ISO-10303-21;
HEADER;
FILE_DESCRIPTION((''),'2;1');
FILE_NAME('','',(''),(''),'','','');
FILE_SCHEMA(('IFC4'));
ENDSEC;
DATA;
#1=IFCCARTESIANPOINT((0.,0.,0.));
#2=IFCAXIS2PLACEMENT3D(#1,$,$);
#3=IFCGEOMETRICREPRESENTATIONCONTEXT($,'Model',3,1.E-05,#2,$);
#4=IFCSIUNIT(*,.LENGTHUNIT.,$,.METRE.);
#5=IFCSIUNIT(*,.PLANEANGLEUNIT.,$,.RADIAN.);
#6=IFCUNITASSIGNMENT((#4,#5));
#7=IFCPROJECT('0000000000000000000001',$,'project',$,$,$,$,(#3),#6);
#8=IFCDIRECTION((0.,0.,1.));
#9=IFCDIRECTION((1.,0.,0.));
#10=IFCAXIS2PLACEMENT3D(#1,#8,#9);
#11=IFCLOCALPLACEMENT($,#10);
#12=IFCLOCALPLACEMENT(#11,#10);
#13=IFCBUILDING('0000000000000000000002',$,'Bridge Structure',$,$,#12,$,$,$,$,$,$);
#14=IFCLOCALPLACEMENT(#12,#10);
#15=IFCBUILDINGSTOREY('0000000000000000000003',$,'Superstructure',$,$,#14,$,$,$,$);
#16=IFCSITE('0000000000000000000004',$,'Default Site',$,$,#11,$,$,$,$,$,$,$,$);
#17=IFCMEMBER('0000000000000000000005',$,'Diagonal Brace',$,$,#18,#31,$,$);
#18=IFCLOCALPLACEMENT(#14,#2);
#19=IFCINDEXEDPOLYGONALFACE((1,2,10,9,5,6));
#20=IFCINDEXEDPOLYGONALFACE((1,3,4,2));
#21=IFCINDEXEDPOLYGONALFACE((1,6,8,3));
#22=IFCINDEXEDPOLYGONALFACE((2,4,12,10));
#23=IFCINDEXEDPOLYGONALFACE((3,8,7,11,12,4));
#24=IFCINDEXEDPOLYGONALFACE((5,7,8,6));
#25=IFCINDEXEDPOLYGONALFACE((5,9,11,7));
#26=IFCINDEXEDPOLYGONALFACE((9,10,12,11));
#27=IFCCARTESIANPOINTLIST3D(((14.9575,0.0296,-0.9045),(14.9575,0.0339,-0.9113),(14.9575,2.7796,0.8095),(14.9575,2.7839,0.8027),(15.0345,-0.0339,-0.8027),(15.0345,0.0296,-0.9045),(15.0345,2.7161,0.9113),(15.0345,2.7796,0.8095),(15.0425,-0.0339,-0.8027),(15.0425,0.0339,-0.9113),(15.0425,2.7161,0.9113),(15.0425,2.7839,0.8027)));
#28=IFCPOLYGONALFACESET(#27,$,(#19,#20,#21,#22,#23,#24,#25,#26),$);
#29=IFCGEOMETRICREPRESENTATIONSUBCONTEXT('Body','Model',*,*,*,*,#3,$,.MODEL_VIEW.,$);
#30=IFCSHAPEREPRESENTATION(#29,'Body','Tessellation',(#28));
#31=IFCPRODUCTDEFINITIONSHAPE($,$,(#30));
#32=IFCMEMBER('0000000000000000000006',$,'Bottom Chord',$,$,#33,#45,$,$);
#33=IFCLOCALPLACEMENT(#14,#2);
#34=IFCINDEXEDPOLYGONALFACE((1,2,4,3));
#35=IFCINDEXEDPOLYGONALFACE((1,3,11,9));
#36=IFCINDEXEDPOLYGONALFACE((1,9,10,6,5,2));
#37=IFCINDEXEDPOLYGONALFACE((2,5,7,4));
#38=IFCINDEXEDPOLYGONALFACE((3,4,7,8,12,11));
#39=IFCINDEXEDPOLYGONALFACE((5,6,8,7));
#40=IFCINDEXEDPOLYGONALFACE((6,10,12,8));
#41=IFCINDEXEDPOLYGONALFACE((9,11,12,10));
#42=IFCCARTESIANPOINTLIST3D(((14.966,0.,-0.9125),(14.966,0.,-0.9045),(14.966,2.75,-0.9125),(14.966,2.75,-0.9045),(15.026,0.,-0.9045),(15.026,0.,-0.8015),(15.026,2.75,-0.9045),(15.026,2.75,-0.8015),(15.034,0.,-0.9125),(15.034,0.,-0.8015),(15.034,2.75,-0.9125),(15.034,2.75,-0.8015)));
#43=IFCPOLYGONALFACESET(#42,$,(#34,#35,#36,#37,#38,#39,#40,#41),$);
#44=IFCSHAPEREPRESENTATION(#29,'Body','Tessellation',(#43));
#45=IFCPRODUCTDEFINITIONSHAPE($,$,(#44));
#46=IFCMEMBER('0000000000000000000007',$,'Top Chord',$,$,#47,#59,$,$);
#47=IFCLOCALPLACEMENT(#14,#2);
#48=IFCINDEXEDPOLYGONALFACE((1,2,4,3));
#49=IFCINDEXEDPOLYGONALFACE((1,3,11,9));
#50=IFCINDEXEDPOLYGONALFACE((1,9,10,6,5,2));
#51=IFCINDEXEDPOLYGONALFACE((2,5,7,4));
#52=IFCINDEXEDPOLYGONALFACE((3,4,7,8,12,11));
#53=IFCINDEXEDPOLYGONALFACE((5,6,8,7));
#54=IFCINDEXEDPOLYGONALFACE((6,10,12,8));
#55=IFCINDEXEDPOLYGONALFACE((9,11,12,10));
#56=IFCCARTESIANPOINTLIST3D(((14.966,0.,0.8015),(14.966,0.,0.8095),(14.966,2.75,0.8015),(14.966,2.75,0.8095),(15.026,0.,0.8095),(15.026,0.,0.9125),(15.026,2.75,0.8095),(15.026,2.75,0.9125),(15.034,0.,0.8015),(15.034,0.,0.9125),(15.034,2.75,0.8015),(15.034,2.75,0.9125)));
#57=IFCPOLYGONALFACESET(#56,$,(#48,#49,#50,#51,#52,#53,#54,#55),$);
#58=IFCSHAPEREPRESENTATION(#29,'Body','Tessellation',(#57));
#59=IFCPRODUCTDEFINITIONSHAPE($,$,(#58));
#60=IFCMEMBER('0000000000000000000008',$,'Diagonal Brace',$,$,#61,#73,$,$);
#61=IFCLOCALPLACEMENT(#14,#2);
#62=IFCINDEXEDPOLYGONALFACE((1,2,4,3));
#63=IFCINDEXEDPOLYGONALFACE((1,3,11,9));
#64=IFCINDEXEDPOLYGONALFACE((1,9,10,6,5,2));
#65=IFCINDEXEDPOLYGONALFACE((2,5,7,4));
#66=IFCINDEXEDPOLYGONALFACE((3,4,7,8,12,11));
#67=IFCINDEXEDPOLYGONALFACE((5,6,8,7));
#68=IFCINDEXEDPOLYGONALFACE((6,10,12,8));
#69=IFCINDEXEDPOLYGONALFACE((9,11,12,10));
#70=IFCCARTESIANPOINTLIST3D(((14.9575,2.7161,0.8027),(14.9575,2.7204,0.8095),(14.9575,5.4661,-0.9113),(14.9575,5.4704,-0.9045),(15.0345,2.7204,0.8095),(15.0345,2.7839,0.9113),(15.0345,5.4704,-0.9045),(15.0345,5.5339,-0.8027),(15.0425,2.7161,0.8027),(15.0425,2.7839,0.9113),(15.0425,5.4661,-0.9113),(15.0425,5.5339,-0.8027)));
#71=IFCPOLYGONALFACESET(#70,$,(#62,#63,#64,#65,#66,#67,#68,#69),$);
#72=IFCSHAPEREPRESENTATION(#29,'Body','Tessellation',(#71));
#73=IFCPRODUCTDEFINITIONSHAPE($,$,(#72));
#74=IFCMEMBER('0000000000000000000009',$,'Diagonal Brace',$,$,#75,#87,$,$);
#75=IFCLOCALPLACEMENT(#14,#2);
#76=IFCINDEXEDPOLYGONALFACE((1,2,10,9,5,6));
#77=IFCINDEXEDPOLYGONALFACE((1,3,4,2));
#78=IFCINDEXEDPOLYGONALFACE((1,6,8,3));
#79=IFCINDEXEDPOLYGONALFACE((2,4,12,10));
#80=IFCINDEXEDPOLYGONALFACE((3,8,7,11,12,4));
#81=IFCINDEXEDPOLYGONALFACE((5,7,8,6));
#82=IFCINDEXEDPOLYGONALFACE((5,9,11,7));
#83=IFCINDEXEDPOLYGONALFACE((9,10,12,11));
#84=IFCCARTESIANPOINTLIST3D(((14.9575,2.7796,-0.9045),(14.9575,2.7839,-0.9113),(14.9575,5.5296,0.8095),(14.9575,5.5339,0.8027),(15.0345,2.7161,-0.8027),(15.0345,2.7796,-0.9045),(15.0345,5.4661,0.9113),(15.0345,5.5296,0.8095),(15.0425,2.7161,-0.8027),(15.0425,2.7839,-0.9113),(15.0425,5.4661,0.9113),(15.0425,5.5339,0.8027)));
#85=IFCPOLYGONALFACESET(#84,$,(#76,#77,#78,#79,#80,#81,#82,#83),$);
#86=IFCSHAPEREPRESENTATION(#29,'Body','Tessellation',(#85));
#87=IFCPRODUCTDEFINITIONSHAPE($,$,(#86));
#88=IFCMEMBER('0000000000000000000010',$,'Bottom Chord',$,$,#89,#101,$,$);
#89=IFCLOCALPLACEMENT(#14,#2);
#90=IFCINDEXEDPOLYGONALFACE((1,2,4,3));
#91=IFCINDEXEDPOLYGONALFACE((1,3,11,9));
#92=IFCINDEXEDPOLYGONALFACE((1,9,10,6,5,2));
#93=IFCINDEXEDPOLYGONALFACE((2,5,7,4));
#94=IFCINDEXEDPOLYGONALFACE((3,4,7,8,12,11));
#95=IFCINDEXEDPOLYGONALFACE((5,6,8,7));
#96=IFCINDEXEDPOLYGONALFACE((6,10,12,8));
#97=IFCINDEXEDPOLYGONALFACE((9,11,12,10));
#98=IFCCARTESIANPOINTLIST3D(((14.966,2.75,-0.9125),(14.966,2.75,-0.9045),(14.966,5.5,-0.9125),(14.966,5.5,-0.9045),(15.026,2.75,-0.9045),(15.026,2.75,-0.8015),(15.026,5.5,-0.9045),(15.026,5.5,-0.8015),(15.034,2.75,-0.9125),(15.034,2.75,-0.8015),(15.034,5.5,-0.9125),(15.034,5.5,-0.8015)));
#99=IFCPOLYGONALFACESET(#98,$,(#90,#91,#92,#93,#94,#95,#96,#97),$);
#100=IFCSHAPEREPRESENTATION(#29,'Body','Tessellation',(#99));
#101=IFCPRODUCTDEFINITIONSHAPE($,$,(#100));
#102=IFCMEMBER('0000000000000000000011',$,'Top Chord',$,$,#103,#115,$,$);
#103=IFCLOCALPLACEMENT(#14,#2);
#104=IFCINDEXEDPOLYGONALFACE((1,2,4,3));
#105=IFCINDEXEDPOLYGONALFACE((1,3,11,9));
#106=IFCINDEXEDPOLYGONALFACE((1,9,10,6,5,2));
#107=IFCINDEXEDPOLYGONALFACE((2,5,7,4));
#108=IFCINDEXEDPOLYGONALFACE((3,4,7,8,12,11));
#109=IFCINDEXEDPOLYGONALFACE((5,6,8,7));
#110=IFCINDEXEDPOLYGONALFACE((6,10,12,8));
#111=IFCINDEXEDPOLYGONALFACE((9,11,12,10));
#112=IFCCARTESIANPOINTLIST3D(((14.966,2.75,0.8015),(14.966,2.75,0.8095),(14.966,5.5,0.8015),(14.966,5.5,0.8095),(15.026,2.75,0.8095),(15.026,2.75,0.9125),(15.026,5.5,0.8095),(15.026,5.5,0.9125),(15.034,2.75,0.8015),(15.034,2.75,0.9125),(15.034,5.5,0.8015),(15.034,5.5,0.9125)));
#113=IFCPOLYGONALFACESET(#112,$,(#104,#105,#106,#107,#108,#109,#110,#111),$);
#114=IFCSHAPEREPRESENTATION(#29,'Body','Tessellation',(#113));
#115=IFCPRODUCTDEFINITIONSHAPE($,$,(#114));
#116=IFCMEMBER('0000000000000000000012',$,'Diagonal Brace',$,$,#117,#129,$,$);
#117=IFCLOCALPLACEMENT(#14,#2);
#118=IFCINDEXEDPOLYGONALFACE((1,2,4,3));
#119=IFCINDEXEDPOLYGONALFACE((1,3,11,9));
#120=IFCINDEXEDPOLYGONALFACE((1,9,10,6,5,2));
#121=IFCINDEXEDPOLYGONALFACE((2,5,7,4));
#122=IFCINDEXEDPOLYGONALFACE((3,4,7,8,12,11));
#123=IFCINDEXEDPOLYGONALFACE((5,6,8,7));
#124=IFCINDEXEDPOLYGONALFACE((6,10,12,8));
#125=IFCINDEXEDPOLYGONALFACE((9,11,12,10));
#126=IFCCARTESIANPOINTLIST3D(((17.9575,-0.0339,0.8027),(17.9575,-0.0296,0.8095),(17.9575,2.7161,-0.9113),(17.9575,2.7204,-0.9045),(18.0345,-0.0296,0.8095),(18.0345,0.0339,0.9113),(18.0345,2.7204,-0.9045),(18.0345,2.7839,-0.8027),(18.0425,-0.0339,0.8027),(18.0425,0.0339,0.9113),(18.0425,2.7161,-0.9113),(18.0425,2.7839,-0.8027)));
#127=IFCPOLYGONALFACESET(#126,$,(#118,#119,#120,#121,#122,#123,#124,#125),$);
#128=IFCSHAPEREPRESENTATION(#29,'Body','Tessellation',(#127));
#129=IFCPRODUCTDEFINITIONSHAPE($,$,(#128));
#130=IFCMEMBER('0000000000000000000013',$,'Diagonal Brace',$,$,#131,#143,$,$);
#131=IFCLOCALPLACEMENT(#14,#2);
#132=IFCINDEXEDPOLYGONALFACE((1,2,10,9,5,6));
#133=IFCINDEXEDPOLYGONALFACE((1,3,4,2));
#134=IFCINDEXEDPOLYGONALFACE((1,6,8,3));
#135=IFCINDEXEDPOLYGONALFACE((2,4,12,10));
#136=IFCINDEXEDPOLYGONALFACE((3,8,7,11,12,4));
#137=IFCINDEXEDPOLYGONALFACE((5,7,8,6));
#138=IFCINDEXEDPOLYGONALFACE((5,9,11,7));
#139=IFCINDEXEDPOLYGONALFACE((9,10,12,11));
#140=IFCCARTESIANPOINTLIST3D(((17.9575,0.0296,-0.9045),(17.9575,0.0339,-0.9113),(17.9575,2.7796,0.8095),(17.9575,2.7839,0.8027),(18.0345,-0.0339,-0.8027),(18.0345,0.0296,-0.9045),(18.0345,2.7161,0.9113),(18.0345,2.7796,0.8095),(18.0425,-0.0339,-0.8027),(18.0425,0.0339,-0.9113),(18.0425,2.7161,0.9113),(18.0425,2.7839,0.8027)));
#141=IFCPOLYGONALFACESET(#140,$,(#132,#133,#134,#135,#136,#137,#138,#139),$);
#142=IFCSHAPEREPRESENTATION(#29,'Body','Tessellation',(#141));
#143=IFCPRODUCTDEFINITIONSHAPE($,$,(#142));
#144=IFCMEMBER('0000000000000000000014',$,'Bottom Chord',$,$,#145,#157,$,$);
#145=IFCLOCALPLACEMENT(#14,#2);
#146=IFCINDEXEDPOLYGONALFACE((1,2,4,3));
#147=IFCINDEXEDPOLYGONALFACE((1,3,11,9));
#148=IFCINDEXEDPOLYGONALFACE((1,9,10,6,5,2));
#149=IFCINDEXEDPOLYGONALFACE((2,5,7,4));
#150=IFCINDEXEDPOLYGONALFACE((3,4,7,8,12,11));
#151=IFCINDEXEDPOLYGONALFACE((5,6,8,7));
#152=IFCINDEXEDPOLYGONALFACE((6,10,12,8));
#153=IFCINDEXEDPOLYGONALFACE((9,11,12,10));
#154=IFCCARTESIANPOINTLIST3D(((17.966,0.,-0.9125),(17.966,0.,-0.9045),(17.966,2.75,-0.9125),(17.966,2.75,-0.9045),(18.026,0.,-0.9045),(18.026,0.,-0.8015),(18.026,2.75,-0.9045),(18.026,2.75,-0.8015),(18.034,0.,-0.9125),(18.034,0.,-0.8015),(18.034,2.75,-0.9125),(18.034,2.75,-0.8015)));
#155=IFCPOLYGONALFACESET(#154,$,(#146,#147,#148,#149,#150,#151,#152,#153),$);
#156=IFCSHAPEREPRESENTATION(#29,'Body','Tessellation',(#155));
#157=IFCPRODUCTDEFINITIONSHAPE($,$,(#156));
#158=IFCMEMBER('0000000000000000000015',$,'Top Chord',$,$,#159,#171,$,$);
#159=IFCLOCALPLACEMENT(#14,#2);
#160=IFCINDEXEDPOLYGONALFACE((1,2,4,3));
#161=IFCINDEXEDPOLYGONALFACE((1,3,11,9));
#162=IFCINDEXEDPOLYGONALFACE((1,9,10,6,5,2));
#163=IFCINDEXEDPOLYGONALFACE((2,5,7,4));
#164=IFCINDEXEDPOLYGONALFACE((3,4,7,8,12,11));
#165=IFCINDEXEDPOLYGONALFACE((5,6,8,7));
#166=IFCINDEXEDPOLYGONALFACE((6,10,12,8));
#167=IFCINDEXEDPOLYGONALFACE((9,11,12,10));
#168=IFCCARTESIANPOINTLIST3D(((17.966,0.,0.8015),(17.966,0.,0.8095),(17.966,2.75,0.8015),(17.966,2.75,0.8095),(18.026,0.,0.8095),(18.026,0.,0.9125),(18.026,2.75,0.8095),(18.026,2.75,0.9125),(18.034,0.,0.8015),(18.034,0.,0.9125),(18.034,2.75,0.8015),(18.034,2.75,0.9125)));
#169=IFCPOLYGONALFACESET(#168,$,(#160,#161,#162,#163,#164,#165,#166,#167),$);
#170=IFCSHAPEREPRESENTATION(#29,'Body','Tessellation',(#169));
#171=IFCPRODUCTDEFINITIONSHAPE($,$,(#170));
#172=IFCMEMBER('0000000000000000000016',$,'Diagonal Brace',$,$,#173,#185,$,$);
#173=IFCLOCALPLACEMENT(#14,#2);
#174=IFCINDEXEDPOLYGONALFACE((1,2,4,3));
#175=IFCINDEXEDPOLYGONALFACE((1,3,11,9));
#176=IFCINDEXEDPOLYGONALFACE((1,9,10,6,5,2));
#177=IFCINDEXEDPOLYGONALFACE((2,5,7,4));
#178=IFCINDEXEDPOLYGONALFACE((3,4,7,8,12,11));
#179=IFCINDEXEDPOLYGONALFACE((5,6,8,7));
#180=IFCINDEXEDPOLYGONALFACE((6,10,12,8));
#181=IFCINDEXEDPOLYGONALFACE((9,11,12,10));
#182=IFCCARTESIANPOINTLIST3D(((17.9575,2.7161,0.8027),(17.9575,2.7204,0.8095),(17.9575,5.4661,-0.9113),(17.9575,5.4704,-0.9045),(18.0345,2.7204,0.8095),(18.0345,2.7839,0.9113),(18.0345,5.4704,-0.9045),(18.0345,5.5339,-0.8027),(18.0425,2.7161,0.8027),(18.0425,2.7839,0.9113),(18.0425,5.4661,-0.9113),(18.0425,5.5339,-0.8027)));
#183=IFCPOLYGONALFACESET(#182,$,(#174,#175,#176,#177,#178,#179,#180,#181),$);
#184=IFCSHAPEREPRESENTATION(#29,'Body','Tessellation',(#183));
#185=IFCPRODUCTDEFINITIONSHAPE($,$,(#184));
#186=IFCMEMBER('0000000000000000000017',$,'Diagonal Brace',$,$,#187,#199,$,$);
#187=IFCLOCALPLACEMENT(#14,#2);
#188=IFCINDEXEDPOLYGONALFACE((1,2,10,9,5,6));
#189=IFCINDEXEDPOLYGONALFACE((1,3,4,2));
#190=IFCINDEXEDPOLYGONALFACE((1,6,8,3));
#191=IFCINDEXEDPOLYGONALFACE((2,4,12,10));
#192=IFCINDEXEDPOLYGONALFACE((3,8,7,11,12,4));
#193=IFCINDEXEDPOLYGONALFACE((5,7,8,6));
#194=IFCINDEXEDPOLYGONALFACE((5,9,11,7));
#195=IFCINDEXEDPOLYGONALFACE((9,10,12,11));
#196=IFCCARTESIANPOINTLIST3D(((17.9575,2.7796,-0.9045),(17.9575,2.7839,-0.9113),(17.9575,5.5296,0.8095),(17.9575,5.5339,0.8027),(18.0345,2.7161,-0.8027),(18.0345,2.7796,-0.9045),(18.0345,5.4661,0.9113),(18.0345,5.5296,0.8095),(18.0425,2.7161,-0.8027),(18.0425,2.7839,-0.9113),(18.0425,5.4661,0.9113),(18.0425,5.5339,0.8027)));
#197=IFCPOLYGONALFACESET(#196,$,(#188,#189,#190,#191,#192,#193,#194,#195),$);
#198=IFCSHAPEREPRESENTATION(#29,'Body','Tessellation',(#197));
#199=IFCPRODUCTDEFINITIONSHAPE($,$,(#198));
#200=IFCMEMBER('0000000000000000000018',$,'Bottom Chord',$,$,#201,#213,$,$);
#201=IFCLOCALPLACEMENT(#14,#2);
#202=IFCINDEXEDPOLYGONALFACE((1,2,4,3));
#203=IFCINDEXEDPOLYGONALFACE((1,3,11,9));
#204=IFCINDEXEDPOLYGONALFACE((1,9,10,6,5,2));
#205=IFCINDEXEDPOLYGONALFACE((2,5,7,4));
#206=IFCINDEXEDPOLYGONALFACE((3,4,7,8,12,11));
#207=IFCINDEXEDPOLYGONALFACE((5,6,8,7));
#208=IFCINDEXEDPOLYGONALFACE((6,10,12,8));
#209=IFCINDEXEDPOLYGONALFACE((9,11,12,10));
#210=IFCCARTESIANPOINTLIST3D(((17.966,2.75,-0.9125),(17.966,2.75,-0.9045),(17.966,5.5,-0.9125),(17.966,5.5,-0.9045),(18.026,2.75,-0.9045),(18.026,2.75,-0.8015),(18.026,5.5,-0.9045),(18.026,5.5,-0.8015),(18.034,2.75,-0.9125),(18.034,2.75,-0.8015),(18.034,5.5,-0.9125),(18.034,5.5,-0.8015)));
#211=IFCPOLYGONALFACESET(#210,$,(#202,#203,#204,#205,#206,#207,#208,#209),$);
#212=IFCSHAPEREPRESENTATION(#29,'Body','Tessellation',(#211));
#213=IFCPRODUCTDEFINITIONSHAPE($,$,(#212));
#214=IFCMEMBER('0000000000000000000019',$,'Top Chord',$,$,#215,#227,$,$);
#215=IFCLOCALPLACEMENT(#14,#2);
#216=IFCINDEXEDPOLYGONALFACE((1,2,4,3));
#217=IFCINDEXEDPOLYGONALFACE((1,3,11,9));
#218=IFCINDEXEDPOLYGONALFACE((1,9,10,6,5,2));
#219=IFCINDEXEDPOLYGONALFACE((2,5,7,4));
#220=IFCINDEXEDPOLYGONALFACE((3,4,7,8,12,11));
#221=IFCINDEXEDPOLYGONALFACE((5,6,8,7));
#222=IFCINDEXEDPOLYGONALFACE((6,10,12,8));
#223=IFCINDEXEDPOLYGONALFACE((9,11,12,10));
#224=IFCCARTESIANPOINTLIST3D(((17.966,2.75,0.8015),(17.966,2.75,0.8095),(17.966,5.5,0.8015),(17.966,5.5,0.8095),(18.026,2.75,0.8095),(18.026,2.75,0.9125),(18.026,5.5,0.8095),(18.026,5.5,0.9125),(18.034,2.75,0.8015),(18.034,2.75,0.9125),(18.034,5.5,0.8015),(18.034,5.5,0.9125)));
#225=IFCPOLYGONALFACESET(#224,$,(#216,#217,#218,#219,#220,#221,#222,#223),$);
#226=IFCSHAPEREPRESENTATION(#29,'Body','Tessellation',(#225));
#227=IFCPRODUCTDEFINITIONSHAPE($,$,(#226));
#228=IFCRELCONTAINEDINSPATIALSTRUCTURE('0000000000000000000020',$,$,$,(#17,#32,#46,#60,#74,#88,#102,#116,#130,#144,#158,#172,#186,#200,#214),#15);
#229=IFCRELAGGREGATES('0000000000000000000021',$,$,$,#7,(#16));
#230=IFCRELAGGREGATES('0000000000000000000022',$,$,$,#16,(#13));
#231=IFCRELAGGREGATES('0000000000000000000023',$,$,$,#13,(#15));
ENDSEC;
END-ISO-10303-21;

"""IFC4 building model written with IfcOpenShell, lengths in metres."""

from ifc_helpers import new_model, si_unit, frame, origin, origin_with_axes, origin_2d_with_axis, place, context, subcontext, project, spatial, l_section, extrude, element, save


model = new_model("IFC4")

# Units and contexts
model_context = context("Model", 3, precision=1e-05, world=origin())
body_context = subcontext(model_context, "Body", "Model", "MODEL_VIEW")
ifc_project = project(units=[si_unit("LENGTHUNIT", "METRE"), si_unit("PLANEANGLEUNIT", "RADIAN")], contexts=[model_context])

# Site, building, storey
site_placement = place(None, origin_with_axes())
site = spatial("IfcSite", under=ifc_project, at=site_placement, Name="Default Site")
building_placement = place(site_placement, origin_with_axes())
building = spatial("IfcBuilding", under=site, at=building_placement, Name="Bridge Structure")
storey_placement = place(building_placement, origin_with_axes())
storey = spatial("IfcBuildingStorey", under=building, at=storey_placement, Name="Superstructure")

# Members
member_placement = place(storey_placement, frame((15.0, 0.0, -0.857), z_axis=(0.0, 0.848656, 0.528944), x_axis=(-1.0, 0.0, 0.0)))
element("IfcMember", 1, at=member_placement, inside=storey, Name="Diagonal Brace", context=body_context, shape_type="SweptSolid", body=[
    extrude(l_section(Depth=0.128, Width=0.085, Thickness=0.008, at=origin_2d_with_axis()), origin_with_axes(), (0.0, 0.0, 1.0), 3.2404),
])
for number, where, z_axis, x_axis, name in (
    (2, (15.0, 0.0, -0.857), (0.0, 1.0, 0.0), (-1.0, 0.0, 0.0), "Bottom Chord"),
    (3, (15.0, 0.0, 0.857), (0.0, 1.0, 0.0), (-1.0, 0.0, 0.0), "Top Chord"),
):
    element("IfcMember", number, at=place(storey_placement, frame(where, z_axis=z_axis, x_axis=x_axis)), inside=storey, Name=name, context=body_context, shape_type="SweptSolid", body=[
        extrude(l_section(Depth=0.111, Width=0.068, Thickness=0.008, at=origin_2d_with_axis()), origin_with_axes(), (0.0, 0.0, 1.0), 2.75),
    ])
for number, where, z_axis, x_axis, name in (
    (4, (15.0, 2.75, 0.857), (0.0, 0.848656, -0.528944), (-1.0, 0.0, 0.0), "Diagonal Brace"),
    (5, (15.0, 2.75, -0.857), (0.0, 0.848656, 0.528944), (-1.0, 0.0, 0.0), "Diagonal Brace"),
):
    element("IfcMember", number, at=place(storey_placement, frame(where, z_axis=z_axis, x_axis=x_axis)), inside=storey, Name=name, context=body_context, shape_type="SweptSolid", body=[
        extrude(l_section(Depth=0.128, Width=0.085, Thickness=0.008, at=origin_2d_with_axis()), origin_with_axes(), (0.0, 0.0, 1.0), 3.2404),
    ])
for number, where, z_axis, x_axis, name in (
    (6, (15.0, 2.75, -0.857), (0.0, 1.0, 0.0), (-1.0, 0.0, 0.0), "Bottom Chord"),
    (7, (15.0, 2.75, 0.857), (0.0, 1.0, 0.0), (-1.0, 0.0, 0.0), "Top Chord"),
):
    element("IfcMember", number, at=place(storey_placement, frame(where, z_axis=z_axis, x_axis=x_axis)), inside=storey, Name=name, context=body_context, shape_type="SweptSolid", body=[
        extrude(l_section(Depth=0.111, Width=0.068, Thickness=0.008, at=origin_2d_with_axis()), origin_with_axes(), (0.0, 0.0, 1.0), 2.75),
    ])
for number, where, z_axis, x_axis, name in (
    (8, (18.0, 0.0, 0.857), (0.0, 0.848656, -0.528944), (-1.0, 0.0, 0.0), "Diagonal Brace"),
    (9, (18.0, 0.0, -0.857), (0.0, 0.848656, 0.528944), (-1.0, 0.0, 0.0), "Diagonal Brace"),
):
    element("IfcMember", number, at=place(storey_placement, frame(where, z_axis=z_axis, x_axis=x_axis)), inside=storey, Name=name, context=body_context, shape_type="SweptSolid", body=[
        extrude(l_section(Depth=0.128, Width=0.085, Thickness=0.008, at=origin_2d_with_axis()), origin_with_axes(), (0.0, 0.0, 1.0), 3.2404),
    ])
for number, where, z_axis, x_axis, name in (
    (10, (18.0, 0.0, -0.857), (0.0, 1.0, 0.0), (-1.0, 0.0, 0.0), "Bottom Chord"),
    (11, (18.0, 0.0, 0.857), (0.0, 1.0, 0.0), (-1.0, 0.0, 0.0), "Top Chord"),
):
    element("IfcMember", number, at=place(storey_placement, frame(where, z_axis=z_axis, x_axis=x_axis)), inside=storey, Name=name, context=body_context, shape_type="SweptSolid", body=[
        extrude(l_section(Depth=0.111, Width=0.068, Thickness=0.008, at=origin_2d_with_axis()), origin_with_axes(), (0.0, 0.0, 1.0), 2.75),
    ])
for number, where, z_axis, x_axis, name in (
    (12, (18.0, 2.75, 0.857), (0.0, 0.848656, -0.528944), (-1.0, 0.0, 0.0), "Diagonal Brace"),
    (13, (18.0, 2.75, -0.857), (0.0, 0.848656, 0.528944), (-1.0, 0.0, 0.0), "Diagonal Brace"),
):
    element("IfcMember", number, at=place(storey_placement, frame(where, z_axis=z_axis, x_axis=x_axis)), inside=storey, Name=name, context=body_context, shape_type="SweptSolid", body=[
        extrude(l_section(Depth=0.128, Width=0.085, Thickness=0.008, at=origin_2d_with_axis()), origin_with_axes(), (0.0, 0.0, 1.0), 3.2404),
    ])
for number, where, z_axis, x_axis, name in (
    (14, (18.0, 2.75, -0.857), (0.0, 1.0, 0.0), (-1.0, 0.0, 0.0), "Bottom Chord"),
    (15, (18.0, 2.75, 0.857), (0.0, 1.0, 0.0), (-1.0, 0.0, 0.0), "Top Chord"),
):
    element("IfcMember", number, at=place(storey_placement, frame(where, z_axis=z_axis, x_axis=x_axis)), inside=storey, Name=name, context=body_context, shape_type="SweptSolid", body=[
        extrude(l_section(Depth=0.111, Width=0.068, Thickness=0.008, at=origin_2d_with_axis()), origin_with_axes(), (0.0, 0.0, 1.0), 2.75),
    ])

save(model, "model.ifc")
